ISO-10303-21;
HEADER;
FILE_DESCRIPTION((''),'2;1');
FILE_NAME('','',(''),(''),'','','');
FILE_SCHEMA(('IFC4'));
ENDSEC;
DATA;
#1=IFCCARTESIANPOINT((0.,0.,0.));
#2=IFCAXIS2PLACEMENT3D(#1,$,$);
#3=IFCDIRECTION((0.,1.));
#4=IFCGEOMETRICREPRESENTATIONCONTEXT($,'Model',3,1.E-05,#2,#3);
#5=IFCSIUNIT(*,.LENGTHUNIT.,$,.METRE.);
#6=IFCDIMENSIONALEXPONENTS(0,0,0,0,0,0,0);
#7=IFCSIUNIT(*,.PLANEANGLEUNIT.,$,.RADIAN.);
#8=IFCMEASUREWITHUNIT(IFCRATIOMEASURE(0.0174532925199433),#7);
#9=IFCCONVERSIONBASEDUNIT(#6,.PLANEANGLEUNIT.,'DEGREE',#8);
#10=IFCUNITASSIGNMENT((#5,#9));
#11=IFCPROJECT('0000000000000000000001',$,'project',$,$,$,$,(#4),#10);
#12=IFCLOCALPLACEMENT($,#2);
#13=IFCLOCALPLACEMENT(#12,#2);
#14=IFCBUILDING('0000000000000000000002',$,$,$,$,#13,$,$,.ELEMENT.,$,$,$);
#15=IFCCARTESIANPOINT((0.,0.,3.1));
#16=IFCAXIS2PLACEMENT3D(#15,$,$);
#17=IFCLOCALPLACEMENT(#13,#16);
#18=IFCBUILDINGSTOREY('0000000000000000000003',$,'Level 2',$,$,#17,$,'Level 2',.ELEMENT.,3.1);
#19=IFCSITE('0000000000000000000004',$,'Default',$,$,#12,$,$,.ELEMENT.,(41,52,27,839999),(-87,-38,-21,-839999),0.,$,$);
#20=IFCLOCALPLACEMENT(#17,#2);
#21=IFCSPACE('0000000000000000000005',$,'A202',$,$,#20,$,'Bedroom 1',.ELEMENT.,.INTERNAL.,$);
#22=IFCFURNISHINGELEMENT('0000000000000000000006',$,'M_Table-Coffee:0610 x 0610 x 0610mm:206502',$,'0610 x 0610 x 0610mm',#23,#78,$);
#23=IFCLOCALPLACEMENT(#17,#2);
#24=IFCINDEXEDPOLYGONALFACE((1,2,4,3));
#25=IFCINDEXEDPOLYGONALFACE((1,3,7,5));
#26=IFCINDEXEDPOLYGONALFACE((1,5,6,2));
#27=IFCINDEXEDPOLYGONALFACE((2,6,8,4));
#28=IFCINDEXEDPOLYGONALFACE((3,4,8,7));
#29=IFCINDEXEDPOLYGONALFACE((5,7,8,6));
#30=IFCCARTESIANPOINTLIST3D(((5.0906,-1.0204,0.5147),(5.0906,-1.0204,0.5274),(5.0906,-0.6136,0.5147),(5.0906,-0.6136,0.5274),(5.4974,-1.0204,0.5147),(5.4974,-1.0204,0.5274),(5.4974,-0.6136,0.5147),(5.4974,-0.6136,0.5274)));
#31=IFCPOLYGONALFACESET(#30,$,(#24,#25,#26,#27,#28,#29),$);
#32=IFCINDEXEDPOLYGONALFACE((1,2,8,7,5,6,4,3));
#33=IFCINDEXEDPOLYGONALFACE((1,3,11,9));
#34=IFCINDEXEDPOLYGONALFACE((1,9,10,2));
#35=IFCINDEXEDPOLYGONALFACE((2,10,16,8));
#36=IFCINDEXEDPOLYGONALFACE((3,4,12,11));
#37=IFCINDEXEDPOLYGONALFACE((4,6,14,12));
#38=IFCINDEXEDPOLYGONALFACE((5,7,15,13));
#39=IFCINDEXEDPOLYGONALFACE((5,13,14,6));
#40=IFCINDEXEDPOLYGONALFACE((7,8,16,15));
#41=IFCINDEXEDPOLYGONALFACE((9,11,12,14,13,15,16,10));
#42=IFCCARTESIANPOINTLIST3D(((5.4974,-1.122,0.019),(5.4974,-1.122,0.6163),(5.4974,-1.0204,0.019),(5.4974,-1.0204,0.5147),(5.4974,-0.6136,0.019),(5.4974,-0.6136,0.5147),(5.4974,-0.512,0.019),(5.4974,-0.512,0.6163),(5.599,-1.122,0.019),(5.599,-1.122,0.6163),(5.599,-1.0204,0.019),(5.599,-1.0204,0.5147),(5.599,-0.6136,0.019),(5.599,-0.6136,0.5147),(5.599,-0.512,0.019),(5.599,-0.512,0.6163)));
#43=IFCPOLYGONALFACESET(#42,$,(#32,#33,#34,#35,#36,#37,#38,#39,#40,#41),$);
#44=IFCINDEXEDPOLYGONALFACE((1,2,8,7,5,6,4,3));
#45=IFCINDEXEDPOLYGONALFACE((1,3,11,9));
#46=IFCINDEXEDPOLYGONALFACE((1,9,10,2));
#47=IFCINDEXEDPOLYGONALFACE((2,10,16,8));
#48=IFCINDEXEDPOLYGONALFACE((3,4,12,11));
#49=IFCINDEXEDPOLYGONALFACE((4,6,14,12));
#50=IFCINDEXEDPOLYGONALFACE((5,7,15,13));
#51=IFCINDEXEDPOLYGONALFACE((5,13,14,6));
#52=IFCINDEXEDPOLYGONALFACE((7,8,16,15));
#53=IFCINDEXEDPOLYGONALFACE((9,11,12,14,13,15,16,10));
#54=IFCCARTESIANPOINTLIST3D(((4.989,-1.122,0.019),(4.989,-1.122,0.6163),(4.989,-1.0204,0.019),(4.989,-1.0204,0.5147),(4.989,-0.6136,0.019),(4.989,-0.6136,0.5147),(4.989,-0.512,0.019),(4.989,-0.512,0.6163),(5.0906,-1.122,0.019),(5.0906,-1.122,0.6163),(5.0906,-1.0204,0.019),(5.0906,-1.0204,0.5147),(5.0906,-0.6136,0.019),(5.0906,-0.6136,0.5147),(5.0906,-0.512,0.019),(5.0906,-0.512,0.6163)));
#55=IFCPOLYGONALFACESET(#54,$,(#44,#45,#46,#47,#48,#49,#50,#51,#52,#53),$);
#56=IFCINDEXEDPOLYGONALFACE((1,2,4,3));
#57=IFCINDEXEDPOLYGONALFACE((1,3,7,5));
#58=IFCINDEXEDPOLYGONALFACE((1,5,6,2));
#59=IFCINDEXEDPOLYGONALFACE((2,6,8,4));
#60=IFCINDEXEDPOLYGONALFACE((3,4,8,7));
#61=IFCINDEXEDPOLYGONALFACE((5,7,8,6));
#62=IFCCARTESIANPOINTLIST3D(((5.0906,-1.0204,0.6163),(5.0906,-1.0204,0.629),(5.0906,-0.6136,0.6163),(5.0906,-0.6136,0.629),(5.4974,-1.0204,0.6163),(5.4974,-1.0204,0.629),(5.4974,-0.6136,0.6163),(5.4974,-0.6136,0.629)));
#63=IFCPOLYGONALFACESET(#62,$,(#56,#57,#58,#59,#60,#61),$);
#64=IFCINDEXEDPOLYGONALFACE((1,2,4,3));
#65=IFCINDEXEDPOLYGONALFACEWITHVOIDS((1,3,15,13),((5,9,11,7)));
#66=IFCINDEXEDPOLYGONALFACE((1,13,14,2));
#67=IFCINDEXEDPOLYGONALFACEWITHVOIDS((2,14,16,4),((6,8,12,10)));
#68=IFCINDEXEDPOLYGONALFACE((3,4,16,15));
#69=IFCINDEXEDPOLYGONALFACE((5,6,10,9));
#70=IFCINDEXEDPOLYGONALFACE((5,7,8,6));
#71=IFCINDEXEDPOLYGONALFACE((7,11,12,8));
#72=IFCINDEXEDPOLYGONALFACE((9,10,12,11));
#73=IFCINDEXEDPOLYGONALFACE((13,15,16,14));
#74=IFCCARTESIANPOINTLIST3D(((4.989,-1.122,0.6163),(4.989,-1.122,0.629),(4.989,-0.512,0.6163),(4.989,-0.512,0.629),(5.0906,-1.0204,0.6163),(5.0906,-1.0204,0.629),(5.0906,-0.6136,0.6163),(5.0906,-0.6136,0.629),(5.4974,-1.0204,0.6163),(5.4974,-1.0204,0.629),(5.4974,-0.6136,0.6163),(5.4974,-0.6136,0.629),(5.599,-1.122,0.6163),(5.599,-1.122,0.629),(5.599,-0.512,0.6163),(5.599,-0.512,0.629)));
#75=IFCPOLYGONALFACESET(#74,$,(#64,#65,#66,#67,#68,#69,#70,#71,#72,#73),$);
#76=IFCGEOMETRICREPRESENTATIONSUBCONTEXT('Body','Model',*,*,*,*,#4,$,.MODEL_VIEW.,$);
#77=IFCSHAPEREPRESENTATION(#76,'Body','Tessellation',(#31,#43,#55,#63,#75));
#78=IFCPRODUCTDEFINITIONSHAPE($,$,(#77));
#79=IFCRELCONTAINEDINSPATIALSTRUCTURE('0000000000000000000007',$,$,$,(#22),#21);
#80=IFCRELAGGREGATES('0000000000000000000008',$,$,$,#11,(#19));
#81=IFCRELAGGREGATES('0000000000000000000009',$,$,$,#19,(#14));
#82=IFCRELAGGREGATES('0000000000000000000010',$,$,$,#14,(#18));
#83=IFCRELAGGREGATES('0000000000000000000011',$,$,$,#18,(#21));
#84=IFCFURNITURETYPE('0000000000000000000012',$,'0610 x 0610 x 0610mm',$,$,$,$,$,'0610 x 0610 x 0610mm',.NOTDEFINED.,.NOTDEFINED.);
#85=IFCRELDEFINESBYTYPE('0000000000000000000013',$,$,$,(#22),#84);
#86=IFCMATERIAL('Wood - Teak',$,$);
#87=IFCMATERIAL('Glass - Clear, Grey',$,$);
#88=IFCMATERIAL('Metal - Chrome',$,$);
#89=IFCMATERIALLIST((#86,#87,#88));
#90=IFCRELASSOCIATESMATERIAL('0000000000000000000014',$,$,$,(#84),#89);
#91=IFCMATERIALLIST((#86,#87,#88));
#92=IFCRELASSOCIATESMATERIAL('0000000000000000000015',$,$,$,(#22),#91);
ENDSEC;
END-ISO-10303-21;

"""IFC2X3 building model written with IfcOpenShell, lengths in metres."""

from ifc_helpers import new_model, entity, si_unit, converted_unit, direction, frame, origin, origin_2d_with_axis, place, context, subcontext, project, spatial, polyline, rectangle, outline, extrude, source, transform, mapped, material, material_list, type_object, type_shapes, element, save


model = new_model("IFC2X3")

# Units and contexts
model_context = context("Model", 3, precision=1e-05, world=origin(), true_north=direction((0.0, 1.0)))
body_context = subcontext(model_context, "Body", "Model", "MODEL_VIEW")
ifc_project = project(units=[si_unit("LENGTHUNIT", "METRE"), converted_unit("PLANEANGLEUNIT", "DEGREE", entity("IfcRatioMeasure", 0.0174532925199433), si_unit("PLANEANGLEUNIT", "RADIAN"), dimensions=[0, 0, 0, 0, 0, 0, 0])], contexts=[model_context])

# Site, building, storey
site_placement = place(None, origin())
site = spatial("IfcSite", under=ifc_project, at=site_placement, Name="Default", CompositionType="ELEMENT", RefLatitude=(41, 52, 27, 839999), RefLongitude=(-87, -38, -21, -839999), RefElevation=0.0)
building_placement = place(site_placement, origin())
building = spatial("IfcBuilding", under=site, at=building_placement, CompositionType="ELEMENT")
storey_placement = place(building_placement, frame((0.0, 0.0, 3.1)))
storey = spatial("IfcBuildingStorey", under=building, at=storey_placement, Name="Level 2", LongName="Level 2", CompositionType="ELEMENT", Elevation=3.1)

# Shared definitions
ifc_material_1 = material(Name="Wood - Teak")
ifc_material_2 = material(Name="Glass - Clear, Grey")
ifc_material_3 = material(Name="Metal - Chrome")
ifc_material_list_1 = material_list([ifc_material_1, ifc_material_2, ifc_material_3])
furniture_type_1 = type_object("IfcFurnitureType", Name="0610 x 0610 x 0610mm", ElementType="0610 x 0610 x 0610mm", material=ifc_material_list_1)
shared_shape_1 = source(origin(), body_context, "Body", "SweptSolid", [
    extrude(rectangle(XDim=0.4068, YDim=0.4068, at=origin_2d_with_axis()), frame((0.0183, 0.0952, 0.4957), z_axis=(0.0, 0.0, 1.0), x_axis=(-1.0, 0.0, 0.0)), (0.0, 0.0, 1.0), 0.0127),
    extrude(outline(polyline([(-0.2732, -0.305), (0.324, -0.305), (0.324, 0.305), (-0.2732, 0.305), (-0.2732, 0.2034), (0.2225, 0.2034), (0.2225, -0.2034), (-0.2732, -0.2034), (-0.2732, -0.305)])), frame((0.2217, 0.0952, 0.2732), z_axis=(1.0, 0.0, 0.0), x_axis=(0.0, 0.0, 1.0)), (0.0, 0.0, 1.0), 0.1016),
    extrude(outline(polyline([(-0.305, -0.3241), (0.305, -0.3241), (0.305, 0.2733), (0.2034, 0.2733), (0.2034, -0.2224), (-0.2034, -0.2224), (-0.2034, 0.2733), (-0.305, 0.2733), (-0.305, -0.3241)])), frame((-0.2867, 0.0952, 0.2733), z_axis=(1.0, 0.0, 0.0), x_axis=(0.0, -1.0, 0.0)), (0.0, 0.0, 1.0), 0.1016),
    extrude(rectangle(XDim=0.4068, YDim=0.4068, at=origin_2d_with_axis()), frame((0.0183, 0.0952, 0.5973), z_axis=(0.0, 0.0, 1.0), x_axis=(-1.0, 0.0, 0.0)), (0.0, 0.0, 1.0), 0.0127),
    extrude(outline(polyline([(-0.305, -0.305), (0.305, -0.305), (0.305, 0.305), (-0.305, 0.305), (-0.305, -0.305)]), holes=[polyline([(-0.2034, -0.2034), (-0.2034, 0.2034), (0.2034, 0.2034), (0.2034, -0.2034), (-0.2034, -0.2034)])]), frame((0.0183, 0.0952, 0.5973), z_axis=(0.0, 0.0, 1.0), x_axis=(-1.0, 0.0, 0.0)), (0.0, 0.0, 1.0), 0.0127),
])
type_shapes(furniture_type_1, [shared_shape_1])

# Shared definitions
space_1_placement = place(storey_placement, origin())
space_1 = spatial("IfcSpace", under=storey, at=space_1_placement, Name="A202", LongName="Bedroom 1", CompositionType="ELEMENT", InteriorOrExteriorSpace="INTERNAL")

# Furnishing element
ifc_material_list_2 = material_list([ifc_material_1, ifc_material_2, ifc_material_3])
furnishing_1_placement = place(space_1_placement, frame((5.2757, -0.9122, 0.019)))
element("IfcFurnishingElement", 1, at=furnishing_1_placement, inside=space_1, type_object=furniture_type_1, material=ifc_material_list_2, Name="M_Table-Coffee:0610 x 0610 x 0610mm:206502", ObjectType="0610 x 0610 x 0610mm", context=body_context, shape_type="MappedRepresentation", body=[
    mapped(shared_shape_1, transform((0.0, 0.0, 0.0), scale=1.0)),
])

save(model, "model.ifc")
